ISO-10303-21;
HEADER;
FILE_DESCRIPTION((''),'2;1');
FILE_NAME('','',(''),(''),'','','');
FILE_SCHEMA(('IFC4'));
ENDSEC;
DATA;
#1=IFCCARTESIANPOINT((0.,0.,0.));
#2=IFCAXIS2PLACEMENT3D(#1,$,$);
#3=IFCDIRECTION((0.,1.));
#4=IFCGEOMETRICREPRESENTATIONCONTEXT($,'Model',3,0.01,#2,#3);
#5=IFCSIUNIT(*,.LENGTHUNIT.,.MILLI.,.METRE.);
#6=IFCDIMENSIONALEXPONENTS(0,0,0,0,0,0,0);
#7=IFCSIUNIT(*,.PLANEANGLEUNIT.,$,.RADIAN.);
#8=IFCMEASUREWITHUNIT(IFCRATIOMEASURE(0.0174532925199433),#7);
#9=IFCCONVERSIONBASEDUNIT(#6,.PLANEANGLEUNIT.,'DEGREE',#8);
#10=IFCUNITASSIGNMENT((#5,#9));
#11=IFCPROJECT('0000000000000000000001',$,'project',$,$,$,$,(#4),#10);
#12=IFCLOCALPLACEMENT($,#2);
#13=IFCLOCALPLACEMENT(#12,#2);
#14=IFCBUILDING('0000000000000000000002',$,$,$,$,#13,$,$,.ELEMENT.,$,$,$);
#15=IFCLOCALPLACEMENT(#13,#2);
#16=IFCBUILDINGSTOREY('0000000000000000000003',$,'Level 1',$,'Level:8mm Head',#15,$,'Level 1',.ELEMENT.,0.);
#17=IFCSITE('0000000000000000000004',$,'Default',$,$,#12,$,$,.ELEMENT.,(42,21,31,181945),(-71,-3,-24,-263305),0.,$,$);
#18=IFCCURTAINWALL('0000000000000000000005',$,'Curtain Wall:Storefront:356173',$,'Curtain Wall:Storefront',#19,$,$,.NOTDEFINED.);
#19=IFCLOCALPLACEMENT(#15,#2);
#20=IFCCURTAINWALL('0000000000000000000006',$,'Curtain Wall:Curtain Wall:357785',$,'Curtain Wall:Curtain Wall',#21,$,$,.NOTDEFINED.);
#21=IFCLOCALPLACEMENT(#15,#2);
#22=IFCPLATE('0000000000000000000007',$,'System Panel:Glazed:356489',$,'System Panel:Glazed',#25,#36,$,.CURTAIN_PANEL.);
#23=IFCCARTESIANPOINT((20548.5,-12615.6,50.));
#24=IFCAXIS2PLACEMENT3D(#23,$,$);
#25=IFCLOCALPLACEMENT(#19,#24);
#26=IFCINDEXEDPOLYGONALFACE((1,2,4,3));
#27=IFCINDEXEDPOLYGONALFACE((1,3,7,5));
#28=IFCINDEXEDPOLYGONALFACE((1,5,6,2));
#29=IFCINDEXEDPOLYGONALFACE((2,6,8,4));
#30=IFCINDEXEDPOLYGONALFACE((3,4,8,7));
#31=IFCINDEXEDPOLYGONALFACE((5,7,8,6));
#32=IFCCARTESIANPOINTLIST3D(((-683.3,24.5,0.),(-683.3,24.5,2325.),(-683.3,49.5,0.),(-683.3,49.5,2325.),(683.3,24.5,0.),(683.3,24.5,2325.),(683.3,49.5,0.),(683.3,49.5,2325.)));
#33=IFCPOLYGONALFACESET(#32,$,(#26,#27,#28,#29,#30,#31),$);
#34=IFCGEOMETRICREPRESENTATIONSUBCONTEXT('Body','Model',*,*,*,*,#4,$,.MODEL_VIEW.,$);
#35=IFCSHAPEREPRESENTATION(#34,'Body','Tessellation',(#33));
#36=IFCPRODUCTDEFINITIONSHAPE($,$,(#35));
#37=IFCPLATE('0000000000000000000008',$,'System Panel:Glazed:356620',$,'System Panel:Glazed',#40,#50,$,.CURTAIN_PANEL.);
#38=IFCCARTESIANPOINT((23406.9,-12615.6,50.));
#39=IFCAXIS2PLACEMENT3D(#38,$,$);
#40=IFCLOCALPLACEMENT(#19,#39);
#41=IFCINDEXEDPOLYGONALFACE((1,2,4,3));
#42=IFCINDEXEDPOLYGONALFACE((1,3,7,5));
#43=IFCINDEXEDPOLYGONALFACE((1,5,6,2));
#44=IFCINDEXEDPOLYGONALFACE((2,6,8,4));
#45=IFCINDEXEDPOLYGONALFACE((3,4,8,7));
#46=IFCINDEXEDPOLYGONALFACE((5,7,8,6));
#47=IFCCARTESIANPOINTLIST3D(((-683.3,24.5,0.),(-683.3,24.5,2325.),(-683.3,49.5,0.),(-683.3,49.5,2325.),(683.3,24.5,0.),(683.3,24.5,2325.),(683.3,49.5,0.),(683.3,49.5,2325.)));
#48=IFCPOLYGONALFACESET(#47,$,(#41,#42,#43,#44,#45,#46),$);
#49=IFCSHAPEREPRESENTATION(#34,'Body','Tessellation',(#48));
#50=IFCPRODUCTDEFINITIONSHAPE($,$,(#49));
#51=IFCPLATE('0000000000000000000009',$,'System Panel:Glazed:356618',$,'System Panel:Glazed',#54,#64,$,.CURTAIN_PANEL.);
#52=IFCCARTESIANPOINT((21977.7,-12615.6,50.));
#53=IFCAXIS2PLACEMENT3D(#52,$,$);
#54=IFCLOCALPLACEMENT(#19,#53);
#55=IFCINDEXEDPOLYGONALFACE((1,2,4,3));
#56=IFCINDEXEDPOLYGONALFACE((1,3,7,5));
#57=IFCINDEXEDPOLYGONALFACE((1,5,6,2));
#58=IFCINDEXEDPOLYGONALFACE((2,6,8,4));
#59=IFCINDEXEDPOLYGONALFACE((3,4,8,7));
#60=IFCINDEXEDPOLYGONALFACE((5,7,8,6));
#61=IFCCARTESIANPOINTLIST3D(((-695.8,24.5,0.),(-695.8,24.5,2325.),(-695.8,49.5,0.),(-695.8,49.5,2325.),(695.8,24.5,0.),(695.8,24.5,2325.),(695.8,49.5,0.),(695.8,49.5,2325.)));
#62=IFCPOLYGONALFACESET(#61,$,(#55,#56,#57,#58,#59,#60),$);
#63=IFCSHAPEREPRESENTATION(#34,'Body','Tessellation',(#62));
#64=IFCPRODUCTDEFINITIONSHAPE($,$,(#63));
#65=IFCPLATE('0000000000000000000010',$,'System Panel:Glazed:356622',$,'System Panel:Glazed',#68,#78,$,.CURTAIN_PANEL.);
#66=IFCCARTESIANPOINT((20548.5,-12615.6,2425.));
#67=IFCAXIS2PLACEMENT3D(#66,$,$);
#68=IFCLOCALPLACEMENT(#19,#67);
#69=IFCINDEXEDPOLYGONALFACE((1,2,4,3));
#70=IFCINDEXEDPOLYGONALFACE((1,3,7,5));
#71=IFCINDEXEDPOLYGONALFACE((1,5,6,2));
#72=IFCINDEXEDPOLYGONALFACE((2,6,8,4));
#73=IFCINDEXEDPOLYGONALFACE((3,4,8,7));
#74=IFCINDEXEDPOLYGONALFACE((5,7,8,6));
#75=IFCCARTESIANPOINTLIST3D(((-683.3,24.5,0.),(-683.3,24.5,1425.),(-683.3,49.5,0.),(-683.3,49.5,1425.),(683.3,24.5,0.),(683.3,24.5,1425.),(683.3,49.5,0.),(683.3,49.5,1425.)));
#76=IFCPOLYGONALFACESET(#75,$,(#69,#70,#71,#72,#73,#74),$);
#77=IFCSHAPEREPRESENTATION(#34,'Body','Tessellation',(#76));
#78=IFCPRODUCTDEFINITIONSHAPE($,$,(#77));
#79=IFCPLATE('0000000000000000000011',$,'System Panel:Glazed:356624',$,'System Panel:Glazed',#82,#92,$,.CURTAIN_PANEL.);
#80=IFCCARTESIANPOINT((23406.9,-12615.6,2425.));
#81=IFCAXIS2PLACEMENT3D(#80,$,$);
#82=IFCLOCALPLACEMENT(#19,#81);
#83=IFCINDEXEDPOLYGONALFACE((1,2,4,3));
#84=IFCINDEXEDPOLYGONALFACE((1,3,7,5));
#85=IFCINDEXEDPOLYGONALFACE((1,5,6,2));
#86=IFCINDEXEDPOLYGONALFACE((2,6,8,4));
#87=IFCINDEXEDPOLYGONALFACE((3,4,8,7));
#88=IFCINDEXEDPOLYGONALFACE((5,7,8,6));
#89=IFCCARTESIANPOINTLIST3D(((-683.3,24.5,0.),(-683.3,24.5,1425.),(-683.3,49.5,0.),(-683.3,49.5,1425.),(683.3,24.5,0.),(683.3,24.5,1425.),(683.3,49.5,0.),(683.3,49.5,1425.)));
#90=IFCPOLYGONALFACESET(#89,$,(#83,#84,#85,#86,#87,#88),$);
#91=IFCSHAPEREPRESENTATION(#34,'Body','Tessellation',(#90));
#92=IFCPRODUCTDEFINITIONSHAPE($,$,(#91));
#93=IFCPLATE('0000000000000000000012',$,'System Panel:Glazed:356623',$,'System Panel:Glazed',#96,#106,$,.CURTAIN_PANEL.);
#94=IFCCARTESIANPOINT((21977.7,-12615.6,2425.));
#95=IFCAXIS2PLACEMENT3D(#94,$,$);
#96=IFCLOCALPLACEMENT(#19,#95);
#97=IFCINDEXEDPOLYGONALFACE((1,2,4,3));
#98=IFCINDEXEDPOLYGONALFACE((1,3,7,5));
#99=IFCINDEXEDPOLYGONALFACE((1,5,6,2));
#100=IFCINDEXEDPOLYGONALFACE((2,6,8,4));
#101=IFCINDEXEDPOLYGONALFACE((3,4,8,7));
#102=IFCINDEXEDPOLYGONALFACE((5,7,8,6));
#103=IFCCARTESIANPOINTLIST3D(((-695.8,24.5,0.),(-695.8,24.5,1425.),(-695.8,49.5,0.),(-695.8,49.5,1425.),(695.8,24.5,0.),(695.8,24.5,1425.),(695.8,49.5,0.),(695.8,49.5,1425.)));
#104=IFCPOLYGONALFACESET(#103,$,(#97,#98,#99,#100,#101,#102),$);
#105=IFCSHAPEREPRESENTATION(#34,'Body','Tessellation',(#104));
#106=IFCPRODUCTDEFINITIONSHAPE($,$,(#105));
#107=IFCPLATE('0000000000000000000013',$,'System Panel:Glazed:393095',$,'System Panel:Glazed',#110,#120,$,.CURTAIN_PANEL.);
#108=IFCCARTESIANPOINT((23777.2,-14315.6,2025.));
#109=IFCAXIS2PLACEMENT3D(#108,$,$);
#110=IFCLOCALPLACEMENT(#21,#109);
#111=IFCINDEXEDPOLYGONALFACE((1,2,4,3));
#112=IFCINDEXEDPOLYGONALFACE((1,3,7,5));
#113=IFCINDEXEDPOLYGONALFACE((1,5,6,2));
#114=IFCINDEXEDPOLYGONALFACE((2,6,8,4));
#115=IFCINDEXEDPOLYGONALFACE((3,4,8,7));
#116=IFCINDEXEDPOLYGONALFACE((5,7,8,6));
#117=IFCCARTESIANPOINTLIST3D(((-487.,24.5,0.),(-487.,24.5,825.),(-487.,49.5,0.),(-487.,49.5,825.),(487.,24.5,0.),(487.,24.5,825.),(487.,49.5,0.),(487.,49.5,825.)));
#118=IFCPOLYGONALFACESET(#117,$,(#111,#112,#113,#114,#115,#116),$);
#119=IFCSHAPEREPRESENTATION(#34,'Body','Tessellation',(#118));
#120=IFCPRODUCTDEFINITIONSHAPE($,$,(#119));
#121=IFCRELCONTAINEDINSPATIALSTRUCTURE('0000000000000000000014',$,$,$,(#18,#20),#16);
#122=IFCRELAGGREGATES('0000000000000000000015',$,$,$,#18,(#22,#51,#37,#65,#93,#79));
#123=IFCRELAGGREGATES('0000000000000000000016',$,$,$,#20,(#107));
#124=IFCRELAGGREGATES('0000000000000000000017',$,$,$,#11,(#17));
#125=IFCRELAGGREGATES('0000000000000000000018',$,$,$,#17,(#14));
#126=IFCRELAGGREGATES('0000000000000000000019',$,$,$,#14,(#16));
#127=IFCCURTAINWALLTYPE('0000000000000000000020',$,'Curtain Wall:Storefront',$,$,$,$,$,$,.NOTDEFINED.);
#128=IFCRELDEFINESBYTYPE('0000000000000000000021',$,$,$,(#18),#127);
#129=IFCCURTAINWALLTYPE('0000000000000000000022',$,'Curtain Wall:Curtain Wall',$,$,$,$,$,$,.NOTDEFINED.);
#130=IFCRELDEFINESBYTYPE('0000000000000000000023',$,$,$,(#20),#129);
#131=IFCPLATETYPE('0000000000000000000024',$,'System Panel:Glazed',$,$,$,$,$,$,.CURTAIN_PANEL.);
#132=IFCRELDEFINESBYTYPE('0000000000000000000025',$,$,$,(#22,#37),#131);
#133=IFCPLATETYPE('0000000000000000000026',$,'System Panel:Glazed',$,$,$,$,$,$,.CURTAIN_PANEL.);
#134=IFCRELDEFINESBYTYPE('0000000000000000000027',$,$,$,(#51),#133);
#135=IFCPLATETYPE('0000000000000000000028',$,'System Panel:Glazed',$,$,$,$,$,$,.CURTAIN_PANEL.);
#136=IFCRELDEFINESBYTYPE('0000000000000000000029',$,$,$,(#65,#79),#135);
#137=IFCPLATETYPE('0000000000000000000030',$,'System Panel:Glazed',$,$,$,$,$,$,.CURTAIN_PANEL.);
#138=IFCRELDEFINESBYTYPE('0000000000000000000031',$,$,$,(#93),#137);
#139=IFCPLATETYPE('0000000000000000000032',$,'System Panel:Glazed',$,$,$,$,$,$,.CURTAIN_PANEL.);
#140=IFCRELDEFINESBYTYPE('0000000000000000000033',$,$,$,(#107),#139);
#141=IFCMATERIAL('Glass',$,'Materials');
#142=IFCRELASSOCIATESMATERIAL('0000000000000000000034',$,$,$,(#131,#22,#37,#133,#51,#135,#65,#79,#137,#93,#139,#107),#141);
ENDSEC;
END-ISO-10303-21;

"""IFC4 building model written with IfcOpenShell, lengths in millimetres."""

from ifc_helpers import new_model, entity, si_unit, converted_unit, direction, frame, origin, place, context, subcontext, project, spatial, indexed_curve, outline, extrude, shape, source, transform, mapped, material, type_object, type_shapes, element, aggregate, save


model = new_model("IFC4")

# Units and contexts
model_context = context("Model", 3, precision=0.01, world=origin(), true_north=direction((0.0, 1.0)))
body_context = subcontext(model_context, "Body", "Model", "MODEL_VIEW")
footprint_context = subcontext(model_context, "FootPrint", "Model", "MODEL_VIEW")
ifc_project = project(units=[si_unit("LENGTHUNIT", "METRE", prefix="MILLI"), converted_unit("PLANEANGLEUNIT", "DEGREE", entity("IfcRatioMeasure", 0.0174532925199433), si_unit("PLANEANGLEUNIT", "RADIAN"), dimensions=[0, 0, 0, 0, 0, 0, 0])], contexts=[model_context])

# Site, building, storey
site_placement = place(None, origin())
site = spatial("IfcSite", under=ifc_project, at=site_placement, Name="Default", CompositionType="ELEMENT", RefLatitude=(42, 21, 31, 181945), RefLongitude=(-71, -3, -24, -263305), RefElevation=0.0)
building_placement = place(site_placement, origin())
building = spatial("IfcBuilding", under=site, at=building_placement, CompositionType="ELEMENT")
storey_placement = place(building_placement, origin())
storey = spatial("IfcBuildingStorey", under=building, at=storey_placement, Name="Level 1", ObjectType="Level:8mm Head", LongName="Level 1", CompositionType="ELEMENT", Elevation=0.0)

# Curtain walls
curtain_wall_type_1 = type_object("IfcCurtainWallType", Name="Curtain Wall:Storefront", PredefinedType="NOTDEFINED")
curtain_wall_1_placement = place(storey_placement, origin())
curtain_wall_1 = element("IfcCurtainWall", 1, at=curtain_wall_1_placement, inside=storey, type_object=curtain_wall_type_1, Name="Curtain Wall:Storefront:356173", ObjectType="Curtain Wall:Storefront", PredefinedType="NOTDEFINED")
curtain_wall_type_2 = type_object("IfcCurtainWallType", Name="Curtain Wall:Curtain Wall", PredefinedType="NOTDEFINED")
curtain_wall_2_placement = place(storey_placement, origin())
curtain_wall_2 = element("IfcCurtainWall", 2, at=curtain_wall_2_placement, inside=storey, type_object=curtain_wall_type_2, Name="Curtain Wall:Curtain Wall:357785", ObjectType="Curtain Wall:Curtain Wall", PredefinedType="NOTDEFINED")

# Plates
ifc_material_1 = material(Name="Glass", Category="Materials")
plate_type_1 = type_object("IfcPlateType", Name="System Panel:Glazed", PredefinedType="CURTAIN_PANEL", material=ifc_material_1)
shared_shape_1 = source(origin(), body_context, "Body", "SweptSolid", [
    extrude(outline(indexed_curve([(-12.5, -683.3), (12.5, -683.3), (12.5, 683.3), (-12.5, 683.3), (-12.5, -683.3)], self_intersect=False)), frame((0.0, 37.0, 0.0), z_axis=(0.0, 0.0, 1.0), x_axis=(0.0, 1.0, 0.0)), (0.0, 0.0, 1.0), 2325.0),
])
shared_shape_2 = source(origin(), footprint_context, "FootPrint", "Curve2D", [
    entity("IfcIndexedPolyCurve", entity("IfcCartesianPointList2D", [[683.3, 24.5], [683.3, 49.5], [-683.3, 49.5], [-683.3, 24.5], [683.3, 24.5]]), None, False),
])
type_shapes(plate_type_1, [shared_shape_1, shared_shape_2])
plate_1_placement = place(curtain_wall_1_placement, frame((20548.5, -12615.6, 50.0)))
plate_1 = element("IfcPlate", 3, at=plate_1_placement, type_object=plate_type_1, material=ifc_material_1, Name="System Panel:Glazed:356489", ObjectType="System Panel:Glazed", PredefinedType="CURTAIN_PANEL", shapes=[
    shape(body_context, "Body", "MappedRepresentation", [mapped(shared_shape_1, transform((0.0, 0.0, 0.0), scale=1.0))]),
    shape(body_context, "Body", "MappedRepresentation", [mapped(shared_shape_2, transform((0.0, 0.0, 0.0), scale=1.0))]),
])
plate_2_placement = place(curtain_wall_1_placement, frame((23406.9, -12615.6, 50.0)))
plate_2 = element("IfcPlate", 4, at=plate_2_placement, type_object=plate_type_1, material=ifc_material_1, Name="System Panel:Glazed:356620", ObjectType="System Panel:Glazed", PredefinedType="CURTAIN_PANEL", shapes=[
    shape(body_context, "Body", "MappedRepresentation", [mapped(shared_shape_1, transform((0.0, 0.0, 0.0), scale=1.0))]),
    shape(body_context, "Body", "MappedRepresentation", [mapped(shared_shape_2, transform((0.0, 0.0, 0.0), scale=1.0))]),
])
plate_type_2 = type_object("IfcPlateType", Name="System Panel:Glazed", PredefinedType="CURTAIN_PANEL", material=ifc_material_1)
shared_shape_3 = source(origin(), body_context, "Body", "SweptSolid", [
    extrude(outline(indexed_curve([(-12.5, -695.8), (12.5, -695.8), (12.5, 695.8), (-12.5, 695.8), (-12.5, -695.8)], self_intersect=False)), frame((0.0, 37.0, 0.0), z_axis=(0.0, 0.0, 1.0), x_axis=(0.0, 1.0, 0.0)), (0.0, 0.0, 1.0), 2325.0),
])
shared_shape_4 = source(origin(), footprint_context, "FootPrint", "Curve2D", [
    entity("IfcIndexedPolyCurve", entity("IfcCartesianPointList2D", [[695.8, 24.5], [695.8, 49.5], [-695.8, 49.5], [-695.8, 24.5], [695.8, 24.5]]), None, False),
])
type_shapes(plate_type_2, [shared_shape_3, shared_shape_4])
plate_3_placement = place(curtain_wall_1_placement, frame((21977.7, -12615.6, 50.0)))
plate_3 = element("IfcPlate", 5, at=plate_3_placement, type_object=plate_type_2, material=ifc_material_1, Name="System Panel:Glazed:356618", ObjectType="System Panel:Glazed", PredefinedType="CURTAIN_PANEL", shapes=[
    shape(body_context, "Body", "MappedRepresentation", [mapped(shared_shape_3, transform((0.0, 0.0, 0.0), scale=1.0))]),
    shape(body_context, "Body", "MappedRepresentation", [mapped(shared_shape_4, transform((0.0, 0.0, 0.0), scale=1.0))]),
])
plate_type_3 = type_object("IfcPlateType", Name="System Panel:Glazed", PredefinedType="CURTAIN_PANEL", material=ifc_material_1)
shared_shape_5 = source(origin(), body_context, "Body", "SweptSolid", [
    extrude(outline(indexed_curve([(-12.5, -683.3), (12.5, -683.3), (12.5, 683.3), (-12.5, 683.3), (-12.5, -683.3)], self_intersect=False)), frame((0.0, 37.0, 0.0), z_axis=(0.0, 0.0, 1.0), x_axis=(0.0, 1.0, 0.0)), (0.0, 0.0, 1.0), 1425.0),
])
shared_shape_6 = source(origin(), footprint_context, "FootPrint", "Curve2D", [
    entity("IfcIndexedPolyCurve", entity("IfcCartesianPointList2D", [[683.3, 24.5], [683.3, 49.5], [-683.3, 49.5], [-683.3, 24.5], [683.3, 24.5]]), None, False),
])
type_shapes(plate_type_3, [shared_shape_5, shared_shape_6])
plate_4_placement = place(curtain_wall_1_placement, frame((20548.5, -12615.6, 2425.0)))
plate_4 = element("IfcPlate", 6, at=plate_4_placement, type_object=plate_type_3, material=ifc_material_1, Name="System Panel:Glazed:356622", ObjectType="System Panel:Glazed", PredefinedType="CURTAIN_PANEL", shapes=[
    shape(body_context, "Body", "MappedRepresentation", [mapped(shared_shape_5, transform((0.0, 0.0, 0.0), scale=1.0))]),
    shape(body_context, "Body", "MappedRepresentation", [mapped(shared_shape_6, transform((0.0, 0.0, 0.0), scale=1.0))]),
])
plate_5_placement = place(curtain_wall_1_placement, frame((23406.9, -12615.6, 2425.0)))
plate_5 = element("IfcPlate", 7, at=plate_5_placement, type_object=plate_type_3, material=ifc_material_1, Name="System Panel:Glazed:356624", ObjectType="System Panel:Glazed", PredefinedType="CURTAIN_PANEL", shapes=[
    shape(body_context, "Body", "MappedRepresentation", [mapped(shared_shape_5, transform((0.0, 0.0, 0.0), scale=1.0))]),
    shape(body_context, "Body", "MappedRepresentation", [mapped(shared_shape_6, transform((0.0, 0.0, 0.0), scale=1.0))]),
])
plate_type_4 = type_object("IfcPlateType", Name="System Panel:Glazed", PredefinedType="CURTAIN_PANEL", material=ifc_material_1)
shared_shape_7 = source(origin(), body_context, "Body", "SweptSolid", [
    extrude(outline(indexed_curve([(-12.5, -695.8), (12.5, -695.8), (12.5, 695.8), (-12.5, 695.8), (-12.5, -695.8)], self_intersect=False)), frame((0.0, 37.0, 0.0), z_axis=(0.0, 0.0, 1.0), x_axis=(0.0, 1.0, 0.0)), (0.0, 0.0, 1.0), 1425.0),
])
shared_shape_8 = source(origin(), footprint_context, "FootPrint", "Curve2D", [
    entity("IfcIndexedPolyCurve", entity("IfcCartesianPointList2D", [[695.8, 24.5], [695.8, 49.5], [-695.8, 49.5], [-695.8, 24.5], [695.8, 24.5]]), None, False),
])
type_shapes(plate_type_4, [shared_shape_7, shared_shape_8])
plate_6_placement = place(curtain_wall_1_placement, frame((21977.7, -12615.6, 2425.0)))
plate_6 = element("IfcPlate", 8, at=plate_6_placement, type_object=plate_type_4, material=ifc_material_1, Name="System Panel:Glazed:356623", ObjectType="System Panel:Glazed", PredefinedType="CURTAIN_PANEL", shapes=[
    shape(body_context, "Body", "MappedRepresentation", [mapped(shared_shape_7, transform((0.0, 0.0, 0.0), scale=1.0))]),
    shape(body_context, "Body", "MappedRepresentation", [mapped(shared_shape_8, transform((0.0, 0.0, 0.0), scale=1.0))]),
])
aggregate(curtain_wall_1, [plate_1, plate_3, plate_2, plate_4, plate_6, plate_5])
plate_type_5 = type_object("IfcPlateType", Name="System Panel:Glazed", PredefinedType="CURTAIN_PANEL", material=ifc_material_1)
shared_shape_9 = source(origin(), body_context, "Body", "SweptSolid", [
    extrude(outline(indexed_curve([(-12.5, -487.0), (12.5, -487.0), (12.5, 487.0), (-12.5, 487.0), (-12.5, -487.0)], self_intersect=False)), frame((0.0, 37.0, 0.0), z_axis=(0.0, 0.0, 1.0), x_axis=(0.0, 1.0, 0.0)), (0.0, 0.0, 1.0), 825.0),
])
shared_shape_10 = source(origin(), footprint_context, "FootPrint", "Curve2D", [
    entity("IfcIndexedPolyCurve", entity("IfcCartesianPointList2D", [[487.0, 24.5], [487.0, 49.5], [-487.0, 49.5], [-487.0, 24.5], [487.0, 24.5]]), None, False),
])
type_shapes(plate_type_5, [shared_shape_9, shared_shape_10])
plate_7_placement = place(curtain_wall_2_placement, frame((23777.2, -14315.6, 2025.0)))
plate_7 = element("IfcPlate", 9, at=plate_7_placement, type_object=plate_type_5, material=ifc_material_1, Name="System Panel:Glazed:393095", ObjectType="System Panel:Glazed", PredefinedType="CURTAIN_PANEL", shapes=[
    shape(body_context, "Body", "MappedRepresentation", [mapped(shared_shape_9, transform((0.0, 0.0, 0.0), scale=1.0))]),
    shape(body_context, "Body", "MappedRepresentation", [mapped(shared_shape_10, transform((0.0, 0.0, 0.0), scale=1.0))]),
])

aggregate(curtain_wall_2, [plate_7])

save(model, "model.ifc")
